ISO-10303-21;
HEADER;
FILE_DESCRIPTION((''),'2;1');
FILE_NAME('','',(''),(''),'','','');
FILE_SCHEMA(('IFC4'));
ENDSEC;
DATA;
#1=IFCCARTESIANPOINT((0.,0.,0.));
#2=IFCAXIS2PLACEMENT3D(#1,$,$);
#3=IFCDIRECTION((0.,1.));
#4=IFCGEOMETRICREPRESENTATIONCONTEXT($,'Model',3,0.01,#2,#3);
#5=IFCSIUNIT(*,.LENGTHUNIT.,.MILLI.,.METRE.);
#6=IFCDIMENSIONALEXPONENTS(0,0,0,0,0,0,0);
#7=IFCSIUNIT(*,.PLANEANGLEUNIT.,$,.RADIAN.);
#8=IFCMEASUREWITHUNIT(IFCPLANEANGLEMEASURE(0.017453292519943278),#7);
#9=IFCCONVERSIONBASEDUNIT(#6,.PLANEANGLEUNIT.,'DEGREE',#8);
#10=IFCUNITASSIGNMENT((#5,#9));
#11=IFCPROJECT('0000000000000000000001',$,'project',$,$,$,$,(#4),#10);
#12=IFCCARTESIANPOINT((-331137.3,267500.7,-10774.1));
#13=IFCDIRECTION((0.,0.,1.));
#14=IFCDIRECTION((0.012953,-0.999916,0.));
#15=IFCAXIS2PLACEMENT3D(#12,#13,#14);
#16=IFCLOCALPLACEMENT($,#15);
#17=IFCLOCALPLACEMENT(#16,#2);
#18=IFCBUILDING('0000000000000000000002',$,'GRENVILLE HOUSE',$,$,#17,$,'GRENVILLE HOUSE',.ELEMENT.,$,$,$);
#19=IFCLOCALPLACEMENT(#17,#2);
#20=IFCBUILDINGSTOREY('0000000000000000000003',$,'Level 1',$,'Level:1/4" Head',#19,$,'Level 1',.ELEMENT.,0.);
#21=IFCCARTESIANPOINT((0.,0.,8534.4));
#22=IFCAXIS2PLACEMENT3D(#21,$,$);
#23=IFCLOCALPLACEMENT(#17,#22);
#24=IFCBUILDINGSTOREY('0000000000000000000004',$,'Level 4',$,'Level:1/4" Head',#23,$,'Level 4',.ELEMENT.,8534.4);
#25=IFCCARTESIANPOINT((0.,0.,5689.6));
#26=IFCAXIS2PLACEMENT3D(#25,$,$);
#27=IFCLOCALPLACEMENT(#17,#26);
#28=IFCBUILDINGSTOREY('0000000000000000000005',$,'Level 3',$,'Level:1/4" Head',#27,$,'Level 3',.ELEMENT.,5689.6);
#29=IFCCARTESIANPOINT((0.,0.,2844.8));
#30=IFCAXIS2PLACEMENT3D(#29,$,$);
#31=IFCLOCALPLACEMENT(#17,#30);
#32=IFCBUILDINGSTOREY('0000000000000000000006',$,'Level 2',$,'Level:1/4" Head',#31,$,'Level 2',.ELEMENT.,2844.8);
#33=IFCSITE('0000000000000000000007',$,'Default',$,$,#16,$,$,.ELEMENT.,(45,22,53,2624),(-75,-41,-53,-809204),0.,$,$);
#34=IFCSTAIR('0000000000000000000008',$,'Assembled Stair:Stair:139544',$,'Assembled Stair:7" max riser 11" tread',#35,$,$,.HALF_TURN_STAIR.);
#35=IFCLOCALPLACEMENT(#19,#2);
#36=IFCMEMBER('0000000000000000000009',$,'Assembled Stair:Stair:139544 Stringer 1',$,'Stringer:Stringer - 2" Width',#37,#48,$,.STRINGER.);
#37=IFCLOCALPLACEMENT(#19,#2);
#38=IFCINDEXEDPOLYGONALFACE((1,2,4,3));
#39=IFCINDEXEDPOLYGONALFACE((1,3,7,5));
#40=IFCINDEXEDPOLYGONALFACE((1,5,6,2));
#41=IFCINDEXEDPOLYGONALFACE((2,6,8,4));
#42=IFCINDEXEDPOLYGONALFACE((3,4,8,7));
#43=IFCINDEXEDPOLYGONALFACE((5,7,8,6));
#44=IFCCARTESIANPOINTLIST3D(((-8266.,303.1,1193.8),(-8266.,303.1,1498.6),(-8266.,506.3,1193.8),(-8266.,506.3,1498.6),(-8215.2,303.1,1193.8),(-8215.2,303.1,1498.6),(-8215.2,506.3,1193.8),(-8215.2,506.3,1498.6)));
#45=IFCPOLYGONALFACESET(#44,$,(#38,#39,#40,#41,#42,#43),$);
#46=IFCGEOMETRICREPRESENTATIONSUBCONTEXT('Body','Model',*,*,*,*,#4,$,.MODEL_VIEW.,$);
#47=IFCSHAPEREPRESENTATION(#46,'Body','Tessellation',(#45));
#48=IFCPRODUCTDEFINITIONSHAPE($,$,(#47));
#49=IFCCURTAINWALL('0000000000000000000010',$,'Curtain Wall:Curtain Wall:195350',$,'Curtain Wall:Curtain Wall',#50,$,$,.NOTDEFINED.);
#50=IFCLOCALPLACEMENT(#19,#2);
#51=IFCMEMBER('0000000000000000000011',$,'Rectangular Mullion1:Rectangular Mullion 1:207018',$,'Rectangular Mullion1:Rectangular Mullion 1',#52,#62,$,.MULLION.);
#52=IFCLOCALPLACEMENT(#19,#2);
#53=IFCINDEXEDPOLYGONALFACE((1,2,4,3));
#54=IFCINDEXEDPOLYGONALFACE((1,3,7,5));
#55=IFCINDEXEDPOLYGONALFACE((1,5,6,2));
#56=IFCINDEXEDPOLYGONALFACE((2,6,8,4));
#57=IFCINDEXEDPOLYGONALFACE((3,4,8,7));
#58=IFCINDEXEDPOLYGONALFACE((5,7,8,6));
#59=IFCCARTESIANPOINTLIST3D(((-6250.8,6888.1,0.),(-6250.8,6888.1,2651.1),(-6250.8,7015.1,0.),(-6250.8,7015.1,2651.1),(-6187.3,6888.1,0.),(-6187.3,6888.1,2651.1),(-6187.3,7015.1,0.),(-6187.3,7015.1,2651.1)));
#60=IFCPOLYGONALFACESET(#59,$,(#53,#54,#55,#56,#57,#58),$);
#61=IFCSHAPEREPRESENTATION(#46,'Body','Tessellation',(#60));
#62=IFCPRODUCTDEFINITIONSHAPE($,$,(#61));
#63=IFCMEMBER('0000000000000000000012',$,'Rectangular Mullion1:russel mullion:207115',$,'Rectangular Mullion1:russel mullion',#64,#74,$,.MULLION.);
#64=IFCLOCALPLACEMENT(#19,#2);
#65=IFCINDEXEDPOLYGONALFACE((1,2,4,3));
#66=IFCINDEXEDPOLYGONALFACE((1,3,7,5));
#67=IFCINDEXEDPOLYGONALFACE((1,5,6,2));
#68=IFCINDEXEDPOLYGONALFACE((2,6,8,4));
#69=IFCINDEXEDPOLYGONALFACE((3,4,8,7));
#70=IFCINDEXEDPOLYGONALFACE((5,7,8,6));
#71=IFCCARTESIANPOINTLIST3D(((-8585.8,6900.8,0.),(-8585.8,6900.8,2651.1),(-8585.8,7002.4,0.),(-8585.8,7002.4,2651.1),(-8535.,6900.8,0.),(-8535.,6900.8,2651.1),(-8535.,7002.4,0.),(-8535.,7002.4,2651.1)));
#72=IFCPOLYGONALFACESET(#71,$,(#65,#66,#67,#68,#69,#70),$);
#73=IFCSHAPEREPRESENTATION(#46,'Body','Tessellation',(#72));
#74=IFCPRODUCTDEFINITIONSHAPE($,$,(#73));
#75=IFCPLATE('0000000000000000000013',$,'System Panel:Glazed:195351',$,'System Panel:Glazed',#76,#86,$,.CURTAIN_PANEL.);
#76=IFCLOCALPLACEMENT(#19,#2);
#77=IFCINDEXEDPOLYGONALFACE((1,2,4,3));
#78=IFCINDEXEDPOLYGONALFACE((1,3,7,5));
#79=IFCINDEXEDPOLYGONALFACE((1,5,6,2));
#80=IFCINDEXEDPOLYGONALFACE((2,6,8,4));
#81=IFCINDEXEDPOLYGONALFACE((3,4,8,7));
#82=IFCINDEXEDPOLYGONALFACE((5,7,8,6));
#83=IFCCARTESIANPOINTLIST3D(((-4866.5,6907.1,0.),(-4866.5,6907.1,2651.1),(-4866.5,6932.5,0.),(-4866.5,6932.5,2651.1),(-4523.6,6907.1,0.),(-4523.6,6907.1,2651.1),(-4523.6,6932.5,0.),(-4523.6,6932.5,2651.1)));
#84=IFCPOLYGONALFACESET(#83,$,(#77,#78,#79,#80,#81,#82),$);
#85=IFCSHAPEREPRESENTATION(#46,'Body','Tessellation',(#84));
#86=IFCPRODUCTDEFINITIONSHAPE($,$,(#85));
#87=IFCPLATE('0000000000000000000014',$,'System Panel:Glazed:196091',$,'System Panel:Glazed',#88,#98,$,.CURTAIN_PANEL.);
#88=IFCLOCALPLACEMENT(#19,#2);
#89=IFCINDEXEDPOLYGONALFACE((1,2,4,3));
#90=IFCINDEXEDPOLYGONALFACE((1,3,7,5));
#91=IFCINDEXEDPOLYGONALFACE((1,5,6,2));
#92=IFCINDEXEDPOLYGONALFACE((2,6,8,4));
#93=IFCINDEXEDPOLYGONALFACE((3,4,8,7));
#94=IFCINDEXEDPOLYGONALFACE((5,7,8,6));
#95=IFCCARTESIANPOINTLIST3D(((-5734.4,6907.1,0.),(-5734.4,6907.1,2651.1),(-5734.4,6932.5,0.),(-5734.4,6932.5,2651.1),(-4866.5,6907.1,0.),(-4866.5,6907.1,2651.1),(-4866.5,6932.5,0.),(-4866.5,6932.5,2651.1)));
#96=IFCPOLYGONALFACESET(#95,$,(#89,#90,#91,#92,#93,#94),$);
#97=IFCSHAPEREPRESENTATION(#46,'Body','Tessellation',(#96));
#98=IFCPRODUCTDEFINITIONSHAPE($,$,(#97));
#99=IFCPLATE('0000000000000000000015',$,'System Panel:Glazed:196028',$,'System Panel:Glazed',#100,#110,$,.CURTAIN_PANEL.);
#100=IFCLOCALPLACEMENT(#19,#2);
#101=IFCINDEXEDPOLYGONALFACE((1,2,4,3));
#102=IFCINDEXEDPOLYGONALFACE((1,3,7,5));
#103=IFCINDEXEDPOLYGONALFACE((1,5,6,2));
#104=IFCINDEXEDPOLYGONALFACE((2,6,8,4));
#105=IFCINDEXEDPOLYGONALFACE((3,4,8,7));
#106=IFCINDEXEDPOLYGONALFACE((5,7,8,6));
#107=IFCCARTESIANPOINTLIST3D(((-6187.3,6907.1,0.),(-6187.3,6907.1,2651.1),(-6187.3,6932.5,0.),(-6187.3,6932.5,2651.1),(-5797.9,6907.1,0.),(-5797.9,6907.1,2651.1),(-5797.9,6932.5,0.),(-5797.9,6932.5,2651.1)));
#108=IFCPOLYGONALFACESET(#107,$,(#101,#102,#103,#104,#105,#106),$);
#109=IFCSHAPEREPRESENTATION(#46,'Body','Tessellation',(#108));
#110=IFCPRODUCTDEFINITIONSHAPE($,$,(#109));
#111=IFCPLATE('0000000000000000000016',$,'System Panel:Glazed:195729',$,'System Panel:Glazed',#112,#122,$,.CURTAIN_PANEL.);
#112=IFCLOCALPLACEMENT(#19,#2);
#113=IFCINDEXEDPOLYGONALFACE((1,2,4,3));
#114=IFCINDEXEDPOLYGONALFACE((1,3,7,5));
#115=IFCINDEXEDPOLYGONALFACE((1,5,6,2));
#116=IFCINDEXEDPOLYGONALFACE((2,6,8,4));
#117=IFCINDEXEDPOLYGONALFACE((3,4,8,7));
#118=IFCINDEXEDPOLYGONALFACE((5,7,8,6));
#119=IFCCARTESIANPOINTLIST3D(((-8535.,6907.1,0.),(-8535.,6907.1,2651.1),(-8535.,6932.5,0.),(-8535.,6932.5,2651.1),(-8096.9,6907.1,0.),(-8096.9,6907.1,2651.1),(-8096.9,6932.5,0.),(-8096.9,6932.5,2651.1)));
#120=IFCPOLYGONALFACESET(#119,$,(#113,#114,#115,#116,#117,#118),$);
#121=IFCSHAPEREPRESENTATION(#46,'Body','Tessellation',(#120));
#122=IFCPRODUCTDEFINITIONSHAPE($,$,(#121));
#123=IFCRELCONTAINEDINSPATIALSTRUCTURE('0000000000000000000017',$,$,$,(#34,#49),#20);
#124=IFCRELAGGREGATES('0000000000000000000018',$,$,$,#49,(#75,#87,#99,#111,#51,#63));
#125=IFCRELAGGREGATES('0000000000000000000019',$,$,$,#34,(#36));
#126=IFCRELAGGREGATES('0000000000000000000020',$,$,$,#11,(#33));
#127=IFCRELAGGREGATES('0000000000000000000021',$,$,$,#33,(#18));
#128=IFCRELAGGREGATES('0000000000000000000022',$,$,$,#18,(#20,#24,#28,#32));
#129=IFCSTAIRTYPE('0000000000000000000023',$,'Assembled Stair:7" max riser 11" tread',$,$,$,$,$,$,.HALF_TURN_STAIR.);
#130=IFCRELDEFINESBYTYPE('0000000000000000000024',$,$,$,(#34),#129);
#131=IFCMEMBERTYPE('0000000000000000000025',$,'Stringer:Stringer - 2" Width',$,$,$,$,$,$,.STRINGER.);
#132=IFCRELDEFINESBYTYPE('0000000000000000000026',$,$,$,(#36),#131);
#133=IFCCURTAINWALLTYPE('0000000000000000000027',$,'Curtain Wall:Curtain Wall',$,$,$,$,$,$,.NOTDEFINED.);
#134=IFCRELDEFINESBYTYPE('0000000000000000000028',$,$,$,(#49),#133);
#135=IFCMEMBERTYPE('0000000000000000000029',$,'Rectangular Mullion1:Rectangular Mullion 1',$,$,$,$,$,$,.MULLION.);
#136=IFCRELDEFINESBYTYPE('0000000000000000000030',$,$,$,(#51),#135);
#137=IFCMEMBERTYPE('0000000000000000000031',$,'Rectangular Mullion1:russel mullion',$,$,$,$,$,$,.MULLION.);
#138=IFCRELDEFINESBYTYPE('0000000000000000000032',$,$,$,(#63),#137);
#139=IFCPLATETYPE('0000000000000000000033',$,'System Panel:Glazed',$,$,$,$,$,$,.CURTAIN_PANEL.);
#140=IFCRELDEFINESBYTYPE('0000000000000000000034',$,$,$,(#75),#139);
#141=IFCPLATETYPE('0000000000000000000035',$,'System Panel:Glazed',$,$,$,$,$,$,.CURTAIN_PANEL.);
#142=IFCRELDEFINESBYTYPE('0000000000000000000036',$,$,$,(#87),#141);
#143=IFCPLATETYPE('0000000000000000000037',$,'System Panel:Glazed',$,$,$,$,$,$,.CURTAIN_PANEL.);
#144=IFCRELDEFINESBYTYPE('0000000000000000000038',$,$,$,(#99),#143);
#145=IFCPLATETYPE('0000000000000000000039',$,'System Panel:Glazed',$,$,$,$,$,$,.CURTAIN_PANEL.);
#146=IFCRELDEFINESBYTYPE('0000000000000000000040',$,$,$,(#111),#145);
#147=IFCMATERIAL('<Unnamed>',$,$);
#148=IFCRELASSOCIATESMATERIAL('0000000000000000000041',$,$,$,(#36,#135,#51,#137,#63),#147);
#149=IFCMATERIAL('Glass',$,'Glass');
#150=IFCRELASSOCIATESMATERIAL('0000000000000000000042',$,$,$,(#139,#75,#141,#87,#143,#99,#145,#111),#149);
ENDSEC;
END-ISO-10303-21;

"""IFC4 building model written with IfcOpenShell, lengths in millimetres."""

from ifc_helpers import new_model, entity, si_unit, converted_unit, direction, frame, origin, place, context, subcontext, project, spatial, indexed_curve, outline, extrude, source, transform, mapped, material, type_object, type_shapes, element, aggregate, save


model = new_model("IFC4")

# Units and contexts
model_context = context("Model", 3, precision=0.01, world=origin(), true_north=direction((0.0, 1.0)))
body_context = subcontext(model_context, "Body", "Model", "MODEL_VIEW")
ifc_project = project(units=[si_unit("LENGTHUNIT", "METRE", prefix="MILLI"), converted_unit("PLANEANGLEUNIT", "DEGREE", entity("IfcPlaneAngleMeasure", 0.017453292519943278), si_unit("PLANEANGLEUNIT", "RADIAN"), dimensions=[0, 0, 0, 0, 0, 0, 0])], contexts=[model_context])

# Site, building, storey
site_placement = place(None, frame((-331137.3, 267500.7, -10774.1), z_axis=(0.0, 0.0, 1.0), x_axis=(0.012953, -0.999916, 0.0)))
site = spatial("IfcSite", under=ifc_project, at=site_placement, Name="Default", CompositionType="ELEMENT", RefLatitude=(45, 22, 53, 2624), RefLongitude=(-75, -41, -53, -809204), RefElevation=0.0)
building_placement = place(site_placement, origin())
building = spatial("IfcBuilding", under=site, at=building_placement, Name="GRENVILLE HOUSE", LongName="GRENVILLE HOUSE", CompositionType="ELEMENT")
storey_1_placement = place(building_placement, origin())
storey_1 = spatial("IfcBuildingStorey", under=building, at=storey_1_placement, Name="Level 1", ObjectType="Level:1/4\" Head", LongName="Level 1", CompositionType="ELEMENT", Elevation=0.0)

# Stair, member
stair_type = type_object("IfcStairType", Name="Assembled Stair:7\" max riser 11\" tread", PredefinedType="HALF_TURN_STAIR")
stair_placement = place(storey_1_placement, origin())
stair = element("IfcStair", 1, at=stair_placement, inside=storey_1, type_object=stair_type, Name="Assembled Stair:Stair:139544", ObjectType="Assembled Stair:7\" max riser 11\" tread", PredefinedType="HALF_TURN_STAIR")
ifc_material_1 = material(Name="<Unnamed>")
member_type_1 = type_object("IfcMemberType", Name="Stringer:Stringer - 2\" Width", PredefinedType="STRINGER")
member_1_placement = place(stair_placement, frame((-8266.0, 303.1, 1193.8)))
member_1 = element("IfcMember", 2, at=member_1_placement, type_object=member_type_1, material=ifc_material_1, Name="Assembled Stair:Stair:139544 Stringer 1", ObjectType="Stringer:Stringer - 2\" Width", PredefinedType="STRINGER", context=body_context, shape_type="SweptSolid", body=[
    extrude(outline(indexed_curve([(-101.6, -25.4), (101.6, -25.4), (101.6, 25.4), (-101.6, 25.4), (-101.6, -25.4)], self_intersect=False)), frame((25.4, 101.6, 0.0), z_axis=(0.0, 0.0, 1.0), x_axis=(0.0, 1.0, 0.0)), (0.0, 0.0, 1.0), 304.8),
])

# Curtain wall, members, plates
curtain_wall_type = type_object("IfcCurtainWallType", Name="Curtain Wall:Curtain Wall", PredefinedType="NOTDEFINED")
curtain_wall_placement = place(storey_1_placement, origin())
curtain_wall = element("IfcCurtainWall", 3, at=curtain_wall_placement, inside=storey_1, type_object=curtain_wall_type, Name="Curtain Wall:Curtain Wall:195350", ObjectType="Curtain Wall:Curtain Wall", PredefinedType="NOTDEFINED")
member_type_2 = type_object("IfcMemberType", Name="Rectangular Mullion1:Rectangular Mullion 1", PredefinedType="MULLION", material=ifc_material_1)
shared_shape_1 = source(origin(), body_context, "Body", "SweptSolid", [
    extrude(outline(indexed_curve([(-31.8, -63.5), (31.8, -63.5), (31.8, 63.5), (-31.8, 63.5), (-31.8, -63.5)], self_intersect=False)), frame((0.0, 0.0, -2651.1), z_axis=(0.0, 0.0, 1.0), x_axis=(-1.0, 0.0, 0.0)), (0.0, 0.0, 1.0), 2651.1),
])
type_shapes(member_type_2, [shared_shape_1])
member_2_placement = place(curtain_wall_placement, frame((-6219.1, 6951.6, 0.0), z_axis=(0.0, 0.0, -1.0), x_axis=(-1.0, 0.0, 0.0)))
member_2 = element("IfcMember", 4, at=member_2_placement, type_object=member_type_2, material=ifc_material_1, Name="Rectangular Mullion1:Rectangular Mullion 1:207018", ObjectType="Rectangular Mullion1:Rectangular Mullion 1", PredefinedType="MULLION", context=body_context, shape_type="MappedRepresentation", body=[
    mapped(shared_shape_1, transform((0.0, 0.0, 0.0), scale=1.0)),
])
member_type_3 = type_object("IfcMemberType", Name="Rectangular Mullion1:russel mullion", PredefinedType="MULLION", material=ifc_material_1)
shared_shape_2 = source(origin(), body_context, "Body", "SweptSolid", [
    extrude(outline(indexed_curve([(-25.4, -50.8), (25.4, -50.8), (25.4, 50.8), (-25.4, 50.8), (-25.4, -50.8)], self_intersect=False)), frame((0.0, 0.0, -2651.1), z_axis=(0.0, 0.0, 1.0), x_axis=(-1.0, 0.0, 0.0)), (0.0, 0.0, 1.0), 2651.1),
])
type_shapes(member_type_3, [shared_shape_2])
member_3_placement = place(curtain_wall_placement, frame((-8560.4, 6951.6, 0.0), z_axis=(0.0, 0.0, -1.0), x_axis=(-1.0, 0.0, 0.0)))
member_3 = element("IfcMember", 5, at=member_3_placement, type_object=member_type_3, material=ifc_material_1, Name="Rectangular Mullion1:russel mullion:207115", ObjectType="Rectangular Mullion1:russel mullion", PredefinedType="MULLION", context=body_context, shape_type="MappedRepresentation", body=[
    mapped(shared_shape_2, transform((0.0, 0.0, 0.0), scale=1.0)),
])
ifc_material_2 = material(Name="Glass", Category="Glass")
plate_type_1 = type_object("IfcPlateType", Name="System Panel:Glazed", PredefinedType="CURTAIN_PANEL", material=ifc_material_2)
shared_shape_3 = source(origin(), body_context, "Body", "SweptSolid", [
    extrude(outline(indexed_curve([(-12.7, -171.5), (12.7, -171.5), (12.7, 171.5), (-12.7, 171.5), (-12.7, -171.5)], self_intersect=False)), frame((171.5, 12.7, 0.0), z_axis=(0.0, 0.0, 1.0), x_axis=(0.0, 1.0, 0.0)), (0.0, 0.0, 1.0), 2651.1),
])
type_shapes(plate_type_1, [shared_shape_3])
plate_1_placement = place(curtain_wall_placement, frame((-4523.6, 6932.5, 0.0), z_axis=(0.0, 0.0, 1.0), x_axis=(-1.0, 0.0, 0.0)))
plate_1 = element("IfcPlate", 6, at=plate_1_placement, type_object=plate_type_1, material=ifc_material_2, Name="System Panel:Glazed:195351", ObjectType="System Panel:Glazed", PredefinedType="CURTAIN_PANEL", context=body_context, shape_type="MappedRepresentation", body=[
    mapped(shared_shape_3, transform((0.0, 0.0, 0.0), scale=1.0)),
])
plate_type_2 = type_object("IfcPlateType", Name="System Panel:Glazed", PredefinedType="CURTAIN_PANEL", material=ifc_material_2)
shared_shape_4 = source(origin(), body_context, "Body", "SweptSolid", [
    extrude(outline(indexed_curve([(-12.7, -433.9), (12.7, -433.9), (12.7, 433.9), (-12.7, 433.9), (-12.7, -433.9)], self_intersect=False)), frame((433.9, 12.7, 0.0), z_axis=(0.0, 0.0, 1.0), x_axis=(0.0, 1.0, 0.0)), (0.0, 0.0, 1.0), 2651.1),
])
type_shapes(plate_type_2, [shared_shape_4])
plate_2_placement = place(curtain_wall_placement, frame((-4866.5, 6932.5, 0.0), z_axis=(0.0, 0.0, 1.0), x_axis=(-1.0, 0.0, 0.0)))
plate_2 = element("IfcPlate", 7, at=plate_2_placement, type_object=plate_type_2, material=ifc_material_2, Name="System Panel:Glazed:196091", ObjectType="System Panel:Glazed", PredefinedType="CURTAIN_PANEL", context=body_context, shape_type="MappedRepresentation", body=[
    mapped(shared_shape_4, transform((0.0, 0.0, 0.0), scale=1.0)),
])
plate_type_3 = type_object("IfcPlateType", Name="System Panel:Glazed", PredefinedType="CURTAIN_PANEL", material=ifc_material_2)
shared_shape_5 = source(origin(), body_context, "Body", "SweptSolid", [
    extrude(outline(indexed_curve([(-12.7, -194.7), (12.7, -194.7), (12.7, 194.7), (-12.7, 194.7), (-12.7, -194.7)], self_intersect=False)), frame((194.7, 12.7, 0.0), z_axis=(0.0, 0.0, 1.0), x_axis=(0.0, 1.0, 0.0)), (0.0, 0.0, 1.0), 2651.1),
])
type_shapes(plate_type_3, [shared_shape_5])
plate_3_placement = place(curtain_wall_placement, frame((-5797.9, 6932.5, 0.0), z_axis=(0.0, 0.0, 1.0), x_axis=(-1.0, 0.0, 0.0)))
plate_3 = element("IfcPlate", 8, at=plate_3_placement, type_object=plate_type_3, material=ifc_material_2, Name="System Panel:Glazed:196028", ObjectType="System Panel:Glazed", PredefinedType="CURTAIN_PANEL", context=body_context, shape_type="MappedRepresentation", body=[
    mapped(shared_shape_5, transform((0.0, 0.0, 0.0), scale=1.0)),
])
plate_type_4 = type_object("IfcPlateType", Name="System Panel:Glazed", PredefinedType="CURTAIN_PANEL", material=ifc_material_2)
shared_shape_6 = source(origin(), body_context, "Body", "SweptSolid", [
    extrude(outline(indexed_curve([(-12.7, -219.1), (12.7, -219.1), (12.7, 219.1), (-12.7, 219.1), (-12.7, -219.1)], self_intersect=False)), frame((219.1, 12.7, 0.0), z_axis=(0.0, 0.0, 1.0), x_axis=(0.0, 1.0, 0.0)), (0.0, 0.0, 1.0), 2651.1),
])
type_shapes(plate_type_4, [shared_shape_6])
plate_4_placement = place(curtain_wall_placement, frame((-8096.9, 6932.5, 0.0), z_axis=(0.0, 0.0, 1.0), x_axis=(-1.0, 0.0, 0.0)))
plate_4 = element("IfcPlate", 9, at=plate_4_placement, type_object=plate_type_4, material=ifc_material_2, Name="System Panel:Glazed:195729", ObjectType="System Panel:Glazed", PredefinedType="CURTAIN_PANEL", context=body_context, shape_type="MappedRepresentation", body=[
    mapped(shared_shape_6, transform((0.0, 0.0, 0.0), scale=1.0)),
])

# Shared definitions
storey_2_placement = place(building_placement, frame((0.0, 0.0, 8534.4)))
storey_2 = spatial("IfcBuildingStorey", under=building, at=storey_2_placement, Name="Level 4", ObjectType="Level:1/4\" Head", LongName="Level 4", CompositionType="ELEMENT", Elevation=8534.4)

# Shared definitions
storey_3_placement = place(building_placement, frame((0.0, 0.0, 5689.6)))
storey_3 = spatial("IfcBuildingStorey", under=building, at=storey_3_placement, Name="Level 3", ObjectType="Level:1/4\" Head", LongName="Level 3", CompositionType="ELEMENT", Elevation=5689.6)

# Shared definitions
storey_4_placement = place(building_placement, frame((0.0, 0.0, 2844.8)))
storey_4 = spatial("IfcBuildingStorey", under=building, at=storey_4_placement, Name="Level 2", ObjectType="Level:1/4\" Head", LongName="Level 2", CompositionType="ELEMENT", Elevation=2844.8)

aggregate(curtain_wall, [plate_1, plate_2, plate_3, plate_4, member_2, member_3])

aggregate(stair, [member_1])

save(model, "model.ifc")
